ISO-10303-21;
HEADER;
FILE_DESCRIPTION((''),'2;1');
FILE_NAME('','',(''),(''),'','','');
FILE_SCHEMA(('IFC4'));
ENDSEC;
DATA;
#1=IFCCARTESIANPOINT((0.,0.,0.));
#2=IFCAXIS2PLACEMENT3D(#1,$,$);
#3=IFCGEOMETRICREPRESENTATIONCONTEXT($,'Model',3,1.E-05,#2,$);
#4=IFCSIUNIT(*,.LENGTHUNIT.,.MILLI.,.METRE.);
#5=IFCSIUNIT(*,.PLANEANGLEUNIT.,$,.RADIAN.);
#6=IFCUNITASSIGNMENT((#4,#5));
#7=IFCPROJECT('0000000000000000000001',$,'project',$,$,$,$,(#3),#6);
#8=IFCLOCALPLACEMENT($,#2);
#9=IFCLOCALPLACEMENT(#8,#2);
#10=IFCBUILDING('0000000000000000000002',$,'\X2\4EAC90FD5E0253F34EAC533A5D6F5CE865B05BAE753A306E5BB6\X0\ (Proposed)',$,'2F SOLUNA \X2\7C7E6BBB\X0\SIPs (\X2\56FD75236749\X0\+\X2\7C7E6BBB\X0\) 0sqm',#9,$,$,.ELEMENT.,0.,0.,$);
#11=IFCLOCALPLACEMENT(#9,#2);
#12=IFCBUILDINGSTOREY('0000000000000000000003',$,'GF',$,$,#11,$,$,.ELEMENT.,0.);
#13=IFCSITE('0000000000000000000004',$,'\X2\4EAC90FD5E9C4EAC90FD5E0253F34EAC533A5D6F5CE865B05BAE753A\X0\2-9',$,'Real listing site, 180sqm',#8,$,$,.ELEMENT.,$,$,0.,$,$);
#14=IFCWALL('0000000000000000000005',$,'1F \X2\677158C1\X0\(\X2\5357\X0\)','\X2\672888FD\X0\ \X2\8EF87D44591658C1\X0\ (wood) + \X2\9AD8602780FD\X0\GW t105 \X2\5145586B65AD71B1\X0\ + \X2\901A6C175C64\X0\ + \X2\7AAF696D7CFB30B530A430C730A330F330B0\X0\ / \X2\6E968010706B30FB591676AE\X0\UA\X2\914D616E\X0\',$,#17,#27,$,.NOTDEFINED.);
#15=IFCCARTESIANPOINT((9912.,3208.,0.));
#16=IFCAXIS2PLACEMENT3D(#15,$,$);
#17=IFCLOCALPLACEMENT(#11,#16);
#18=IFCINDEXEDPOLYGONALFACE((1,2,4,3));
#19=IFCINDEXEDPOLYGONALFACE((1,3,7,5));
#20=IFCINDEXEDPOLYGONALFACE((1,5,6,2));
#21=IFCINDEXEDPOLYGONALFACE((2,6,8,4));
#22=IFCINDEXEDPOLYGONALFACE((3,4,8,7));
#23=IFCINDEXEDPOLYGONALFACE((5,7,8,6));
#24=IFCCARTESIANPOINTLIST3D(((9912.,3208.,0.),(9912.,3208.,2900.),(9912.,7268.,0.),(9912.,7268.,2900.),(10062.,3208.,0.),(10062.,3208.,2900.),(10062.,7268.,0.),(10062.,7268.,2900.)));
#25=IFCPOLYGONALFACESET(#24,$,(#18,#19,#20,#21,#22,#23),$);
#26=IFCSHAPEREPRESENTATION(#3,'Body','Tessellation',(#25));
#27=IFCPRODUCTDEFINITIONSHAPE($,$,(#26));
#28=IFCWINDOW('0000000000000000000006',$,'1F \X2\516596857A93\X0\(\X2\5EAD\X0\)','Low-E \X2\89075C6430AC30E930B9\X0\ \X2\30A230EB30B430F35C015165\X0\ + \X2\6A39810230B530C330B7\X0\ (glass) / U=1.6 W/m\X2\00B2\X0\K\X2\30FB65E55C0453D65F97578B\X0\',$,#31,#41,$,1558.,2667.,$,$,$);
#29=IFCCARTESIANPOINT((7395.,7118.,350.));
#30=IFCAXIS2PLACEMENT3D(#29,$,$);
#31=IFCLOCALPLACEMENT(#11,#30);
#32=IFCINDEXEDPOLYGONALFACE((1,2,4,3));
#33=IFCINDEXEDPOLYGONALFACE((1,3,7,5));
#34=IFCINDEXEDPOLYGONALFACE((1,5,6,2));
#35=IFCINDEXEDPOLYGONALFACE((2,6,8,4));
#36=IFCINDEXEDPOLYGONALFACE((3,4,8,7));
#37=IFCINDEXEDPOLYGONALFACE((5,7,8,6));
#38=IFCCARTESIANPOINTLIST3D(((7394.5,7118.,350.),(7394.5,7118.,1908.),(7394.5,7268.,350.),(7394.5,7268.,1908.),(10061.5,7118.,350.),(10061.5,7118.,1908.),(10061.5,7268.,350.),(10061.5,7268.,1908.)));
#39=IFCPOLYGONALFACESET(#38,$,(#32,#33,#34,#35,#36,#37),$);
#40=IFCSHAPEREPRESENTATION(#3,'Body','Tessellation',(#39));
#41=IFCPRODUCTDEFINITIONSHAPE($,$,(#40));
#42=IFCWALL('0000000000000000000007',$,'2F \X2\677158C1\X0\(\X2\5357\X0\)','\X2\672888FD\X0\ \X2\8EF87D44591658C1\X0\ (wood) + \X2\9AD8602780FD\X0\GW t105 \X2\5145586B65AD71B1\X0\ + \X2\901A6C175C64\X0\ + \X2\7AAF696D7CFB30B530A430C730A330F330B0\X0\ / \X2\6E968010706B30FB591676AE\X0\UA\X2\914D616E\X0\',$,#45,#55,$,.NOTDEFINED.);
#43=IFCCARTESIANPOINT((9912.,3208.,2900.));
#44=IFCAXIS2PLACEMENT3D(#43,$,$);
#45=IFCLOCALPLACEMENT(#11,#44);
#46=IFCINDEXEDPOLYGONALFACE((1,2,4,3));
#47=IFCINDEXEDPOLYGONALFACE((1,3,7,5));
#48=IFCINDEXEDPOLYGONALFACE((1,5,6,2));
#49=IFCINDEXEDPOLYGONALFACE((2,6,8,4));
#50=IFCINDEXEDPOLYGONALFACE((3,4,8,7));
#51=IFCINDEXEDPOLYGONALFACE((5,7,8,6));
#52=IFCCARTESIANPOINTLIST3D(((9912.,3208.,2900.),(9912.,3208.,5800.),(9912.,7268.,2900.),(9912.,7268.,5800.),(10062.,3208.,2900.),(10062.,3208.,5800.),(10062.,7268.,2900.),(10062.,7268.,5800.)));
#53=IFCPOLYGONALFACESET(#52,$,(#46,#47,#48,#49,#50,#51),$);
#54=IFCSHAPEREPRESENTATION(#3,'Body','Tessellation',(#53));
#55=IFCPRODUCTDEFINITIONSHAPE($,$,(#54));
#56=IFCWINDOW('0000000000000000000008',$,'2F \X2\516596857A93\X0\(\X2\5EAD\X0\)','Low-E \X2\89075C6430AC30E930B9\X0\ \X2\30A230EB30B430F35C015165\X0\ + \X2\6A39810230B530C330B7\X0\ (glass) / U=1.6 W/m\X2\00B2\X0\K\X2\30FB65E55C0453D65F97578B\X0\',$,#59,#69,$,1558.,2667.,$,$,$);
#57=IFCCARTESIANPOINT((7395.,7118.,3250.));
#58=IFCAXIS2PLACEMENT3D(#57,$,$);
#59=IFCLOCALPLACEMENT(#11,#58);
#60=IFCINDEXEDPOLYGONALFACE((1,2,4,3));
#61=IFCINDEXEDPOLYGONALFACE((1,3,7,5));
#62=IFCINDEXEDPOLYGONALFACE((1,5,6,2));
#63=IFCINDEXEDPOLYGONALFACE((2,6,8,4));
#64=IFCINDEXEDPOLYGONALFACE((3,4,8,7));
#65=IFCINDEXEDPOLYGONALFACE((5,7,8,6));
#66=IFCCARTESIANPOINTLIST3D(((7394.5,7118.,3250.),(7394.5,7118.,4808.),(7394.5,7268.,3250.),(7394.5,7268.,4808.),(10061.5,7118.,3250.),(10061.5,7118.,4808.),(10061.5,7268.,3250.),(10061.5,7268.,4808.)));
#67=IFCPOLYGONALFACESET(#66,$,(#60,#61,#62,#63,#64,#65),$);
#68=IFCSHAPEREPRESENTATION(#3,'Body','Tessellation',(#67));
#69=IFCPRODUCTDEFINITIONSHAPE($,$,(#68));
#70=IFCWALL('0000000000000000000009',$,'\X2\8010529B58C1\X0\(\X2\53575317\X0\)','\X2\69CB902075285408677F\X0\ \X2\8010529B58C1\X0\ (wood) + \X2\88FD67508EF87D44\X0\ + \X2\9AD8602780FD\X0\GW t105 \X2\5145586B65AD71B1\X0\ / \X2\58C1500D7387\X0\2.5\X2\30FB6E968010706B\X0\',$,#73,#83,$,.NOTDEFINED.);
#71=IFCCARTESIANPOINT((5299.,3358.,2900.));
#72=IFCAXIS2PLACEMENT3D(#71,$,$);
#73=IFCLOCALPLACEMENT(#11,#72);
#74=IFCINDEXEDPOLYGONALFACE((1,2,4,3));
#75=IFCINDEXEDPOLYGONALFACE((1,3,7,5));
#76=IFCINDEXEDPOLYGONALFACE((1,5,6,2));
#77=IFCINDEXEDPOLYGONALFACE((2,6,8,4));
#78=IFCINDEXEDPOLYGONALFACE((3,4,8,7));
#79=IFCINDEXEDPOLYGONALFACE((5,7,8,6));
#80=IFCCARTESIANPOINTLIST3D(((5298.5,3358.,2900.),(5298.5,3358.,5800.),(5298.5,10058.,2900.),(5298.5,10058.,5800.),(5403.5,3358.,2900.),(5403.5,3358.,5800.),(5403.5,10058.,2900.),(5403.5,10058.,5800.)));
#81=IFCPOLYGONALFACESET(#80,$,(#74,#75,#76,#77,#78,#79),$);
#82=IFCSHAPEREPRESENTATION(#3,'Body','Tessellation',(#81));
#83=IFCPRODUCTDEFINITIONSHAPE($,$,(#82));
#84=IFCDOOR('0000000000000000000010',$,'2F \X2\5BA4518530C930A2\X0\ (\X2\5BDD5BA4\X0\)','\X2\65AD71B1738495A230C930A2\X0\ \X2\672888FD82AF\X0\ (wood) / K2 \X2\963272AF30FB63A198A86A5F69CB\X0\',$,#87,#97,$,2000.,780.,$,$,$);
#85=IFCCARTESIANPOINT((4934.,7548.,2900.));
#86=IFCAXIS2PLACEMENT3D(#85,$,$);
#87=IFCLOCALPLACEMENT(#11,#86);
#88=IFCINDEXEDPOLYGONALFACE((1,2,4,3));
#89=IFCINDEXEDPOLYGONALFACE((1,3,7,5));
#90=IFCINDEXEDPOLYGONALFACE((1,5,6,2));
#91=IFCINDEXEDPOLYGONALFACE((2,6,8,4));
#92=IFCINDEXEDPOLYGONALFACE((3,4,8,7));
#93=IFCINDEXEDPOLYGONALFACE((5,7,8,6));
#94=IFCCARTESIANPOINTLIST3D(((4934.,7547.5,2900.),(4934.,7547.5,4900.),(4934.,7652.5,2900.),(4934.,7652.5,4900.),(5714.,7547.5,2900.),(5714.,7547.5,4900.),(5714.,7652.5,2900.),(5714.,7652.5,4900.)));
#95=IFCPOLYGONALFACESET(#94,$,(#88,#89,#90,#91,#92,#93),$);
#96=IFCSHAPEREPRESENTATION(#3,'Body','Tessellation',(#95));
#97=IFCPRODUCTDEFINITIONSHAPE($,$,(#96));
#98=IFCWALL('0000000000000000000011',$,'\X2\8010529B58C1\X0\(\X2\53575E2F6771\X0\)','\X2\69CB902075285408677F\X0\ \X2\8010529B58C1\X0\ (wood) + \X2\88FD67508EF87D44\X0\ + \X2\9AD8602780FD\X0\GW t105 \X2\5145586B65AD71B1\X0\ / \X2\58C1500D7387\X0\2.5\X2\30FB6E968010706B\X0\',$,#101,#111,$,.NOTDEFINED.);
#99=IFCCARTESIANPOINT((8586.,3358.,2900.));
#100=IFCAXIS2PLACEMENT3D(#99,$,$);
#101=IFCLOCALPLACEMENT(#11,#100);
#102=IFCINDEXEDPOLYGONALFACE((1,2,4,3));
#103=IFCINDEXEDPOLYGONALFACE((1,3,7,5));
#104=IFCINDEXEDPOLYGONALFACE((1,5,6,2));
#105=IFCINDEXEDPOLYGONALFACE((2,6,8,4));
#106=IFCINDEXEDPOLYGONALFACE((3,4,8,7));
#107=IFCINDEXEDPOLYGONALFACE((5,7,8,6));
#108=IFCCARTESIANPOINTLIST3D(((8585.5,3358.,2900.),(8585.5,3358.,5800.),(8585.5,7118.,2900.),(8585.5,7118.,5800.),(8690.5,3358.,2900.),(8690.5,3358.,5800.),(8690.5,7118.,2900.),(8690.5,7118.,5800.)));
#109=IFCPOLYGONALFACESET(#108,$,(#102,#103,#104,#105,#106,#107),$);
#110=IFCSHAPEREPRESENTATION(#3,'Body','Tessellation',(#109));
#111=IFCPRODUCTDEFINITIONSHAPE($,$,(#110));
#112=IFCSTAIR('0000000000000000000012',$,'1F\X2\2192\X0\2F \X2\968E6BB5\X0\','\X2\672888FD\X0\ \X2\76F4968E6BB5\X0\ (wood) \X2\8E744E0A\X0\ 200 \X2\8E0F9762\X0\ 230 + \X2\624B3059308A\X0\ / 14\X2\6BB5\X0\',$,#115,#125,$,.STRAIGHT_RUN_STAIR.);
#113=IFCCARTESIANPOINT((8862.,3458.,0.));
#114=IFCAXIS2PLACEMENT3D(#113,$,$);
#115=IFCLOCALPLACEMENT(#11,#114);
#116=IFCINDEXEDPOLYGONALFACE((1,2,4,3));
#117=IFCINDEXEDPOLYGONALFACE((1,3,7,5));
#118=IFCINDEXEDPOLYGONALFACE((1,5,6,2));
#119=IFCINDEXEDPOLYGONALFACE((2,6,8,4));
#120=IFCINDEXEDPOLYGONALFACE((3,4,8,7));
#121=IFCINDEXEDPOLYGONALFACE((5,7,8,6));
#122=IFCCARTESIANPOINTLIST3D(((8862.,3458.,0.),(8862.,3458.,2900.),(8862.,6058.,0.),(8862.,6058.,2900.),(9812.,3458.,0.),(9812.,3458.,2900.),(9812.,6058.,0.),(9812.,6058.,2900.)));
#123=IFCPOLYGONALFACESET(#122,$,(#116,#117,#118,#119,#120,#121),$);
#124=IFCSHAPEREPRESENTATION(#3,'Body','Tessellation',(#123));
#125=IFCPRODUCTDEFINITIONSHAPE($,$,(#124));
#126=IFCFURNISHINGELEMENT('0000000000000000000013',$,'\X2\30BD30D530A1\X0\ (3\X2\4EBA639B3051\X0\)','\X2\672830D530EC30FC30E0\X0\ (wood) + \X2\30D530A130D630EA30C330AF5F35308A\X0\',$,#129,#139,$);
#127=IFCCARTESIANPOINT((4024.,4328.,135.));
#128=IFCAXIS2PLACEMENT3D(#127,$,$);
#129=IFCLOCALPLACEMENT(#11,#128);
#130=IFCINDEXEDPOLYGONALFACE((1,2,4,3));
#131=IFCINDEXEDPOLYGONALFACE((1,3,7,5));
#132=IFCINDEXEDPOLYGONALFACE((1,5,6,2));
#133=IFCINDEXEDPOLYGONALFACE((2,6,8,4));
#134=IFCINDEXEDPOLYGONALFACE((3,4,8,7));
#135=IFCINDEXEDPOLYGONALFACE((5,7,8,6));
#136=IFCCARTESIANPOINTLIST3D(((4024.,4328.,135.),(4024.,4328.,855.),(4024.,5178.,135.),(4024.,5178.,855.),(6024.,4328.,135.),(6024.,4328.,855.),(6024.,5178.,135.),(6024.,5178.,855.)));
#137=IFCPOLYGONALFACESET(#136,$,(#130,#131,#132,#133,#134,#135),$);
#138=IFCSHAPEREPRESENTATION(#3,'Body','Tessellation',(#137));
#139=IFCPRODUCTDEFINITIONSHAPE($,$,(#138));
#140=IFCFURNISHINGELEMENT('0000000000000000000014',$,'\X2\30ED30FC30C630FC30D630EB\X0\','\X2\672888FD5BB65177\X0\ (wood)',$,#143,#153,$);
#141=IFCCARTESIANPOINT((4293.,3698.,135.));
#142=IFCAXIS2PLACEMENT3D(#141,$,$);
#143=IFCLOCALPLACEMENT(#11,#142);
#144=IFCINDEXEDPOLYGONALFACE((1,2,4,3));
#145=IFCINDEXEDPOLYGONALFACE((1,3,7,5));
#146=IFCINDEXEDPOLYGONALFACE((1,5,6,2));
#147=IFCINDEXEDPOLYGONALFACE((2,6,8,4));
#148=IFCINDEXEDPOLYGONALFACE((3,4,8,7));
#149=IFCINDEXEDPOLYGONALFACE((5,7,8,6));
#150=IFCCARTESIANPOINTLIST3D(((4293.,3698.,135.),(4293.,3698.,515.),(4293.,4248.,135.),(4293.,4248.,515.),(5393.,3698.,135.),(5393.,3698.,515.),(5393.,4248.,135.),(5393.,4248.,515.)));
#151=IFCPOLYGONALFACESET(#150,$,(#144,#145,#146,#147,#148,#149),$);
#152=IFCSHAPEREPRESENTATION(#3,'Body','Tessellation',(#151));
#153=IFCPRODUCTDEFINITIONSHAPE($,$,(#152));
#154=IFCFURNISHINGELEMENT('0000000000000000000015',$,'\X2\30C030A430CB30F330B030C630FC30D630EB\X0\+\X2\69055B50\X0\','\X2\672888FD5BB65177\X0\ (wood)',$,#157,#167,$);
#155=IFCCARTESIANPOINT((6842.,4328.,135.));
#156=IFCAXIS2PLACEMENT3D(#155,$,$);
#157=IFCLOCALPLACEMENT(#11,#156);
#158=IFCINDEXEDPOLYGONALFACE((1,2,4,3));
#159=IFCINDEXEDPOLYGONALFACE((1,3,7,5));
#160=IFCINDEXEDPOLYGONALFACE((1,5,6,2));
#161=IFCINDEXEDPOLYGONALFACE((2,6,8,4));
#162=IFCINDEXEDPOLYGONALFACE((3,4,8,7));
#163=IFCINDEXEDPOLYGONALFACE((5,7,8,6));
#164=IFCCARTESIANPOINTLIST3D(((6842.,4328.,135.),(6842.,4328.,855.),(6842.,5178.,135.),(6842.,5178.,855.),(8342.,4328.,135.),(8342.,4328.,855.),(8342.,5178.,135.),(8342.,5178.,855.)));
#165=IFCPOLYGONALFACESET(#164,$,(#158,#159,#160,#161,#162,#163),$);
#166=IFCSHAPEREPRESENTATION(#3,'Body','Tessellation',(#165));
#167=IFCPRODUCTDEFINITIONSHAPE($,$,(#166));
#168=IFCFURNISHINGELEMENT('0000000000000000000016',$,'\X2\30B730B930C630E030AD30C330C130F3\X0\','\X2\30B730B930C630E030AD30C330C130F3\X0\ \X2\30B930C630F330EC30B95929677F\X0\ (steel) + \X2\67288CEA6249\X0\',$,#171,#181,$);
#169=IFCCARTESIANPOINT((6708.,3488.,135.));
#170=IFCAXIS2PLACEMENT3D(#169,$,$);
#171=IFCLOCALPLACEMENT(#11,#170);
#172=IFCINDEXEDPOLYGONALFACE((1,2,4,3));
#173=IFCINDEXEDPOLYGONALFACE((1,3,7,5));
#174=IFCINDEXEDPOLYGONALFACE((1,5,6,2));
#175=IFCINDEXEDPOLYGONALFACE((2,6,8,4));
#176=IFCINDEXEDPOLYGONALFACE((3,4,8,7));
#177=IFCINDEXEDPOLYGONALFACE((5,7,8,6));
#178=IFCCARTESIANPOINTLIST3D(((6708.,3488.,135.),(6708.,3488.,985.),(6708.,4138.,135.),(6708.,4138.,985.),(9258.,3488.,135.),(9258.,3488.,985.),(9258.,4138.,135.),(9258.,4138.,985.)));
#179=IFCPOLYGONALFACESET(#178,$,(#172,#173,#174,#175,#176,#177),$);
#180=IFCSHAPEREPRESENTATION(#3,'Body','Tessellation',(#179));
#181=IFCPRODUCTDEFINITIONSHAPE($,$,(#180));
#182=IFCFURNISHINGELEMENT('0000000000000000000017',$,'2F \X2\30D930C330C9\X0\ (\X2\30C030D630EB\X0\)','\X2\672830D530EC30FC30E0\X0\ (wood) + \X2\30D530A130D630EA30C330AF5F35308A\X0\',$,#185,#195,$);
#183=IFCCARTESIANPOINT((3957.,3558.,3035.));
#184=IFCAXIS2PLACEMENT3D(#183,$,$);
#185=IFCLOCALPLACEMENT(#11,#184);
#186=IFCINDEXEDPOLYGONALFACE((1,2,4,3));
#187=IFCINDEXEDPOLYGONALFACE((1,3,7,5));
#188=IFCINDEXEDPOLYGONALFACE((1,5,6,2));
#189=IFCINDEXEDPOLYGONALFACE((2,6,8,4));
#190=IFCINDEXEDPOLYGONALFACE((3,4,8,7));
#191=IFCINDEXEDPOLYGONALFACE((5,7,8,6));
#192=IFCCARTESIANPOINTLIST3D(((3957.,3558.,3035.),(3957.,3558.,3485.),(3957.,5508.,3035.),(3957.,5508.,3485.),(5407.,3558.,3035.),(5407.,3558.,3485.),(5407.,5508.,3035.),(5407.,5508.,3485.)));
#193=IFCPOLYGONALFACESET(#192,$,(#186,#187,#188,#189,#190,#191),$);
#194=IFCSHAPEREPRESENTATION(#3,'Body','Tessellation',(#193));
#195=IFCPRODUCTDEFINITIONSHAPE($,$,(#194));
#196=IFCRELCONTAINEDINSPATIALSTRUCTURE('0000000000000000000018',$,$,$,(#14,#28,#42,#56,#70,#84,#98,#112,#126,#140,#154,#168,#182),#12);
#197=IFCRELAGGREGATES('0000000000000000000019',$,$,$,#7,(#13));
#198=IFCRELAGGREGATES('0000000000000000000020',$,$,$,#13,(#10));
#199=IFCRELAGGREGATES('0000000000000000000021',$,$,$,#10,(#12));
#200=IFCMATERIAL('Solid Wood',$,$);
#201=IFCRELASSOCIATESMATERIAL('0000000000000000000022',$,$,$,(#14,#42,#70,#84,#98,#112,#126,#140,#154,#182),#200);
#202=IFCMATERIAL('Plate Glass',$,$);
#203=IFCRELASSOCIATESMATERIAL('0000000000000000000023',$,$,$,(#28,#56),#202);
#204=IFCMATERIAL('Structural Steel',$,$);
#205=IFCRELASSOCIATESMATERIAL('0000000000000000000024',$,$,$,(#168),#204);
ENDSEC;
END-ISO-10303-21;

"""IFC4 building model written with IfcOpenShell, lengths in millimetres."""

from ifc_helpers import new_model, si_unit, frame, frame_2d, origin, place, context, project, spatial, rectangle, extrude, material, element, fill, save


model = new_model("IFC4")

# Units and contexts
model_context = context("Model", 3, precision=1e-05, world=origin())
ifc_project = project(units=[si_unit("LENGTHUNIT", "METRE", prefix="MILLI"), si_unit("PLANEANGLEUNIT", "RADIAN")], contexts=[model_context])

# Site, building, storey
site_placement = place(None, origin())
site = spatial("IfcSite", under=ifc_project, at=site_placement, Name="京都府京都市右京区嵯峨新宮町2-9", ObjectType="Real listing site, 180sqm", CompositionType="ELEMENT", RefElevation=0.0)
building_placement = place(site_placement, origin())
building = spatial("IfcBuilding", under=site, at=building_placement, Name="京都市右京区嵯峨新宮町の家 (Proposed)", ObjectType="2F SOLUNA 籾殻SIPs (国産杉+籾殻) 0sqm", CompositionType="ELEMENT", ElevationOfRefHeight=0.0, ElevationOfTerrain=0.0)
storey_placement = place(building_placement, origin())
storey = spatial("IfcBuildingStorey", under=building, at=storey_placement, Name="GF", CompositionType="ELEMENT", Elevation=0.0)

# Wall, opening, window
ifc_material_1 = material(Name="Solid Wood")
wall_1_placement = place(storey_placement, frame((9912.0, 3208.0, 0.0)))
wall_1 = element("IfcWall", 1, at=wall_1_placement, inside=storey, material=ifc_material_1, Name="1F 東壁(南)", Description="木製 軸組外壁 (wood) + 高性能GW t105 充填断熱 + 通気層 + 窯業系サイディング / 準耐火・外皮UA配慮", PredefinedType="NOTDEFINED", context=model_context, shape_type="SweptSolid", body=[
    extrude(rectangle(XDim=150.0, YDim=4060.0, at=frame_2d((75.0, 2030.0))), frame((9912.0, 3208.0, 0.0)), (0.0, 0.0, 1.0), 2900.0),
])
opening_1_placement = place(storey_placement, frame((7395.0, 7118.0, 350.0)))
opening_1 = element("IfcOpeningElement", 2, at=opening_1_placement, cuts=wall_1, PredefinedType="NOTDEFINED", context=model_context, shape_type="SweptSolid", body=[
    extrude(rectangle(XDim=2667.0, YDim=150.0, at=frame_2d((1333.0, 75.0))), frame((7395.0, 7118.0, 350.0)), (0.0, 0.0, 1.0), 1558.0),
])
ifc_material_2 = material(Name="Plate Glass")
window_1_placement = place(storey_placement, frame((7395.0, 7118.0, 350.0)))
window_1 = element("IfcWindow", 3, at=window_1_placement, inside=storey, material=ifc_material_2, Name="1F 入隅窓(庭)", Description="Low-E 複層ガラス アルゴン封入 + 樹脂サッシ (glass) / U=1.6 W/m²K・日射取得型", OverallHeight=1558.0, OverallWidth=2667.0, context=model_context, shape_type="SweptSolid", body=[
    extrude(rectangle(XDim=2667.0, YDim=150.0, at=frame_2d((1333.0, 75.0))), frame((7395.0, 7118.0, 350.0)), (0.0, 0.0, 1.0), 1558.0),
])
fill(opening_1, window_1)

# Wall, opening, window
wall_2_placement = place(storey_placement, frame((9912.0, 3208.0, 2900.0)))
wall_2 = element("IfcWall", 4, at=wall_2_placement, inside=storey, material=ifc_material_1, Name="2F 東壁(南)", Description="木製 軸組外壁 (wood) + 高性能GW t105 充填断熱 + 通気層 + 窯業系サイディング / 準耐火・外皮UA配慮", PredefinedType="NOTDEFINED", context=model_context, shape_type="SweptSolid", body=[
    extrude(rectangle(XDim=150.0, YDim=4060.0, at=frame_2d((75.0, 2030.0))), frame((9912.0, 3208.0, 2900.0)), (0.0, 0.0, 1.0), 2900.0),
])
opening_2_placement = place(storey_placement, frame((7395.0, 7118.0, 3250.0)))
opening_2 = element("IfcOpeningElement", 5, at=opening_2_placement, cuts=wall_2, PredefinedType="NOTDEFINED", context=model_context, shape_type="SweptSolid", body=[
    extrude(rectangle(XDim=2667.0, YDim=150.0, at=frame_2d((1333.0, 75.0))), frame((7395.0, 7118.0, 3250.0)), (0.0, 0.0, 1.0), 1558.0),
])
window_2_placement = place(storey_placement, frame((7395.0, 7118.0, 3250.0)))
window_2 = element("IfcWindow", 6, at=window_2_placement, inside=storey, material=ifc_material_2, Name="2F 入隅窓(庭)", Description="Low-E 複層ガラス アルゴン封入 + 樹脂サッシ (glass) / U=1.6 W/m²K・日射取得型", OverallHeight=1558.0, OverallWidth=2667.0, context=model_context, shape_type="SweptSolid", body=[
    extrude(rectangle(XDim=2667.0, YDim=150.0, at=frame_2d((1333.0, 75.0))), frame((7395.0, 7118.0, 3250.0)), (0.0, 0.0, 1.0), 1558.0),
])
fill(opening_2, window_2)

# Wall, opening, door
wall_3_placement = place(storey_placement, frame((5299.0, 3358.0, 2900.0)))
wall_3 = element("IfcWall", 7, at=wall_3_placement, inside=storey, material=ifc_material_1, Name="耐力壁(南北)", Description="構造用合板 耐力壁 (wood) + 製材軸組 + 高性能GW t105 充填断熱 / 壁倍率2.5・準耐火", PredefinedType="NOTDEFINED", context=model_context, shape_type="SweptSolid", body=[
    extrude(rectangle(XDim=105.0, YDim=6700.0, at=frame_2d((52.0, 3350.0))), frame((5299.0, 3358.0, 2900.0)), (0.0, 0.0, 1.0), 2900.0),
])
opening_3_placement = place(storey_placement, frame((4934.0, 7548.0, 2900.0)))
opening_3 = element("IfcOpeningElement", 8, at=opening_3_placement, cuts=wall_3, PredefinedType="NOTDEFINED", context=model_context, shape_type="SweptSolid", body=[
    extrude(rectangle(XDim=780.0, YDim=105.0, at=frame_2d((390.0, 52.0))), frame((4934.0, 7548.0, 2900.0)), (0.0, 0.0, 1.0), 2000.0),
])
door_1_placement = place(storey_placement, frame((4934.0, 7548.0, 2900.0)))
door_1 = element("IfcDoor", 9, at=door_1_placement, inside=storey, material=ifc_material_1, Name="2F 室内ドア (寝室)", Description="断熱玄関ドア 木製芯 (wood) / K2 防犯・採風機構", OverallHeight=2000.0, OverallWidth=780.0, context=model_context, shape_type="SweptSolid", body=[
    extrude(rectangle(XDim=780.0, YDim=105.0, at=frame_2d((390.0, 52.0))), frame((4934.0, 7548.0, 2900.0)), (0.0, 0.0, 1.0), 2000.0),
])
fill(opening_3, door_1)

# Wall
wall_4_placement = place(storey_placement, frame((8586.0, 3358.0, 2900.0)))
element("IfcWall", 10, at=wall_4_placement, inside=storey, material=ifc_material_1, Name="耐力壁(南帯東)", Description="構造用合板 耐力壁 (wood) + 製材軸組 + 高性能GW t105 充填断熱 / 壁倍率2.5・準耐火", PredefinedType="NOTDEFINED", context=model_context, shape_type="SweptSolid", body=[
    extrude(rectangle(XDim=105.0, YDim=3760.0, at=frame_2d((52.0, 1880.0))), frame((8586.0, 3358.0, 2900.0)), (0.0, 0.0, 1.0), 2900.0),
])

# Stair
stair_placement = place(storey_placement, frame((8862.0, 3458.0, 0.0)))
element("IfcStair", 11, at=stair_placement, inside=storey, material=ifc_material_1, Name="1F→2F 階段", Description="木製 直階段 (wood) 蹴上 200 踏面 230 + 手すり / 14段", PredefinedType="STRAIGHT_RUN_STAIR", context=model_context, shape_type="SweptSolid", body=[
    extrude(rectangle(XDim=950.0, YDim=2600.0, at=frame_2d((475.0, 1300.0))), frame((8862.0, 3458.0, 0.0)), (0.0, 0.0, 1.0), 2900.0),
])

# Furnishing elements
furnishing_1_placement = place(storey_placement, frame((4024.0, 4328.0, 135.0)))
element("IfcFurnishingElement", 12, at=furnishing_1_placement, inside=storey, material=ifc_material_1, Name="ソファ (3人掛け)", Description="木フレーム (wood) + ファブリック張り", context=model_context, shape_type="SweptSolid", body=[
    extrude(rectangle(XDim=2000.0, YDim=850.0, at=frame_2d((1000.0, 425.0))), frame((4024.0, 4328.0, 135.0)), (0.0, 0.0, 1.0), 720.0),
])
furnishing_2_placement = place(storey_placement, frame((4293.0, 3698.0, 135.0)))
element("IfcFurnishingElement", 13, at=furnishing_2_placement, inside=storey, material=ifc_material_1, Name="ローテーブル", Description="木製家具 (wood)", context=model_context, shape_type="SweptSolid", body=[
    extrude(rectangle(XDim=1100.0, YDim=550.0, at=frame_2d((550.0, 275.0))), frame((4293.0, 3698.0, 135.0)), (0.0, 0.0, 1.0), 380.0),
])
furnishing_3_placement = place(storey_placement, frame((6842.0, 4328.0, 135.0)))
element("IfcFurnishingElement", 14, at=furnishing_3_placement, inside=storey, material=ifc_material_1, Name="ダイニングテーブル+椅子", Description="木製家具 (wood)", context=model_context, shape_type="SweptSolid", body=[
    extrude(rectangle(XDim=1500.0, YDim=850.0, at=frame_2d((750.0, 425.0))), frame((6842.0, 4328.0, 135.0)), (0.0, 0.0, 1.0), 720.0),
])
ifc_material_3 = material(Name="Structural Steel")
furnishing_4_placement = place(storey_placement, frame((6708.0, 3488.0, 135.0)))
element("IfcFurnishingElement", 15, at=furnishing_4_placement, inside=storey, material=ifc_material_3, Name="システムキッチン", Description="システムキッチン ステンレス天板 (steel) + 木質扉", context=model_context, shape_type="SweptSolid", body=[
    extrude(rectangle(XDim=2550.0, YDim=650.0, at=frame_2d((1275.0, 325.0))), frame((6708.0, 3488.0, 135.0)), (0.0, 0.0, 1.0), 850.0),
])
furnishing_5_placement = place(storey_placement, frame((3957.0, 3558.0, 3035.0)))
element("IfcFurnishingElement", 16, at=furnishing_5_placement, inside=storey, material=ifc_material_1, Name="2F ベッド (ダブル)", Description="木フレーム (wood) + ファブリック張り", context=model_context, shape_type="SweptSolid", body=[
    extrude(rectangle(XDim=1450.0, YDim=1950.0, at=frame_2d((725.0, 975.0))), frame((3957.0, 3558.0, 3035.0)), (0.0, 0.0, 1.0), 450.0),
])

save(model, "model.ifc")
